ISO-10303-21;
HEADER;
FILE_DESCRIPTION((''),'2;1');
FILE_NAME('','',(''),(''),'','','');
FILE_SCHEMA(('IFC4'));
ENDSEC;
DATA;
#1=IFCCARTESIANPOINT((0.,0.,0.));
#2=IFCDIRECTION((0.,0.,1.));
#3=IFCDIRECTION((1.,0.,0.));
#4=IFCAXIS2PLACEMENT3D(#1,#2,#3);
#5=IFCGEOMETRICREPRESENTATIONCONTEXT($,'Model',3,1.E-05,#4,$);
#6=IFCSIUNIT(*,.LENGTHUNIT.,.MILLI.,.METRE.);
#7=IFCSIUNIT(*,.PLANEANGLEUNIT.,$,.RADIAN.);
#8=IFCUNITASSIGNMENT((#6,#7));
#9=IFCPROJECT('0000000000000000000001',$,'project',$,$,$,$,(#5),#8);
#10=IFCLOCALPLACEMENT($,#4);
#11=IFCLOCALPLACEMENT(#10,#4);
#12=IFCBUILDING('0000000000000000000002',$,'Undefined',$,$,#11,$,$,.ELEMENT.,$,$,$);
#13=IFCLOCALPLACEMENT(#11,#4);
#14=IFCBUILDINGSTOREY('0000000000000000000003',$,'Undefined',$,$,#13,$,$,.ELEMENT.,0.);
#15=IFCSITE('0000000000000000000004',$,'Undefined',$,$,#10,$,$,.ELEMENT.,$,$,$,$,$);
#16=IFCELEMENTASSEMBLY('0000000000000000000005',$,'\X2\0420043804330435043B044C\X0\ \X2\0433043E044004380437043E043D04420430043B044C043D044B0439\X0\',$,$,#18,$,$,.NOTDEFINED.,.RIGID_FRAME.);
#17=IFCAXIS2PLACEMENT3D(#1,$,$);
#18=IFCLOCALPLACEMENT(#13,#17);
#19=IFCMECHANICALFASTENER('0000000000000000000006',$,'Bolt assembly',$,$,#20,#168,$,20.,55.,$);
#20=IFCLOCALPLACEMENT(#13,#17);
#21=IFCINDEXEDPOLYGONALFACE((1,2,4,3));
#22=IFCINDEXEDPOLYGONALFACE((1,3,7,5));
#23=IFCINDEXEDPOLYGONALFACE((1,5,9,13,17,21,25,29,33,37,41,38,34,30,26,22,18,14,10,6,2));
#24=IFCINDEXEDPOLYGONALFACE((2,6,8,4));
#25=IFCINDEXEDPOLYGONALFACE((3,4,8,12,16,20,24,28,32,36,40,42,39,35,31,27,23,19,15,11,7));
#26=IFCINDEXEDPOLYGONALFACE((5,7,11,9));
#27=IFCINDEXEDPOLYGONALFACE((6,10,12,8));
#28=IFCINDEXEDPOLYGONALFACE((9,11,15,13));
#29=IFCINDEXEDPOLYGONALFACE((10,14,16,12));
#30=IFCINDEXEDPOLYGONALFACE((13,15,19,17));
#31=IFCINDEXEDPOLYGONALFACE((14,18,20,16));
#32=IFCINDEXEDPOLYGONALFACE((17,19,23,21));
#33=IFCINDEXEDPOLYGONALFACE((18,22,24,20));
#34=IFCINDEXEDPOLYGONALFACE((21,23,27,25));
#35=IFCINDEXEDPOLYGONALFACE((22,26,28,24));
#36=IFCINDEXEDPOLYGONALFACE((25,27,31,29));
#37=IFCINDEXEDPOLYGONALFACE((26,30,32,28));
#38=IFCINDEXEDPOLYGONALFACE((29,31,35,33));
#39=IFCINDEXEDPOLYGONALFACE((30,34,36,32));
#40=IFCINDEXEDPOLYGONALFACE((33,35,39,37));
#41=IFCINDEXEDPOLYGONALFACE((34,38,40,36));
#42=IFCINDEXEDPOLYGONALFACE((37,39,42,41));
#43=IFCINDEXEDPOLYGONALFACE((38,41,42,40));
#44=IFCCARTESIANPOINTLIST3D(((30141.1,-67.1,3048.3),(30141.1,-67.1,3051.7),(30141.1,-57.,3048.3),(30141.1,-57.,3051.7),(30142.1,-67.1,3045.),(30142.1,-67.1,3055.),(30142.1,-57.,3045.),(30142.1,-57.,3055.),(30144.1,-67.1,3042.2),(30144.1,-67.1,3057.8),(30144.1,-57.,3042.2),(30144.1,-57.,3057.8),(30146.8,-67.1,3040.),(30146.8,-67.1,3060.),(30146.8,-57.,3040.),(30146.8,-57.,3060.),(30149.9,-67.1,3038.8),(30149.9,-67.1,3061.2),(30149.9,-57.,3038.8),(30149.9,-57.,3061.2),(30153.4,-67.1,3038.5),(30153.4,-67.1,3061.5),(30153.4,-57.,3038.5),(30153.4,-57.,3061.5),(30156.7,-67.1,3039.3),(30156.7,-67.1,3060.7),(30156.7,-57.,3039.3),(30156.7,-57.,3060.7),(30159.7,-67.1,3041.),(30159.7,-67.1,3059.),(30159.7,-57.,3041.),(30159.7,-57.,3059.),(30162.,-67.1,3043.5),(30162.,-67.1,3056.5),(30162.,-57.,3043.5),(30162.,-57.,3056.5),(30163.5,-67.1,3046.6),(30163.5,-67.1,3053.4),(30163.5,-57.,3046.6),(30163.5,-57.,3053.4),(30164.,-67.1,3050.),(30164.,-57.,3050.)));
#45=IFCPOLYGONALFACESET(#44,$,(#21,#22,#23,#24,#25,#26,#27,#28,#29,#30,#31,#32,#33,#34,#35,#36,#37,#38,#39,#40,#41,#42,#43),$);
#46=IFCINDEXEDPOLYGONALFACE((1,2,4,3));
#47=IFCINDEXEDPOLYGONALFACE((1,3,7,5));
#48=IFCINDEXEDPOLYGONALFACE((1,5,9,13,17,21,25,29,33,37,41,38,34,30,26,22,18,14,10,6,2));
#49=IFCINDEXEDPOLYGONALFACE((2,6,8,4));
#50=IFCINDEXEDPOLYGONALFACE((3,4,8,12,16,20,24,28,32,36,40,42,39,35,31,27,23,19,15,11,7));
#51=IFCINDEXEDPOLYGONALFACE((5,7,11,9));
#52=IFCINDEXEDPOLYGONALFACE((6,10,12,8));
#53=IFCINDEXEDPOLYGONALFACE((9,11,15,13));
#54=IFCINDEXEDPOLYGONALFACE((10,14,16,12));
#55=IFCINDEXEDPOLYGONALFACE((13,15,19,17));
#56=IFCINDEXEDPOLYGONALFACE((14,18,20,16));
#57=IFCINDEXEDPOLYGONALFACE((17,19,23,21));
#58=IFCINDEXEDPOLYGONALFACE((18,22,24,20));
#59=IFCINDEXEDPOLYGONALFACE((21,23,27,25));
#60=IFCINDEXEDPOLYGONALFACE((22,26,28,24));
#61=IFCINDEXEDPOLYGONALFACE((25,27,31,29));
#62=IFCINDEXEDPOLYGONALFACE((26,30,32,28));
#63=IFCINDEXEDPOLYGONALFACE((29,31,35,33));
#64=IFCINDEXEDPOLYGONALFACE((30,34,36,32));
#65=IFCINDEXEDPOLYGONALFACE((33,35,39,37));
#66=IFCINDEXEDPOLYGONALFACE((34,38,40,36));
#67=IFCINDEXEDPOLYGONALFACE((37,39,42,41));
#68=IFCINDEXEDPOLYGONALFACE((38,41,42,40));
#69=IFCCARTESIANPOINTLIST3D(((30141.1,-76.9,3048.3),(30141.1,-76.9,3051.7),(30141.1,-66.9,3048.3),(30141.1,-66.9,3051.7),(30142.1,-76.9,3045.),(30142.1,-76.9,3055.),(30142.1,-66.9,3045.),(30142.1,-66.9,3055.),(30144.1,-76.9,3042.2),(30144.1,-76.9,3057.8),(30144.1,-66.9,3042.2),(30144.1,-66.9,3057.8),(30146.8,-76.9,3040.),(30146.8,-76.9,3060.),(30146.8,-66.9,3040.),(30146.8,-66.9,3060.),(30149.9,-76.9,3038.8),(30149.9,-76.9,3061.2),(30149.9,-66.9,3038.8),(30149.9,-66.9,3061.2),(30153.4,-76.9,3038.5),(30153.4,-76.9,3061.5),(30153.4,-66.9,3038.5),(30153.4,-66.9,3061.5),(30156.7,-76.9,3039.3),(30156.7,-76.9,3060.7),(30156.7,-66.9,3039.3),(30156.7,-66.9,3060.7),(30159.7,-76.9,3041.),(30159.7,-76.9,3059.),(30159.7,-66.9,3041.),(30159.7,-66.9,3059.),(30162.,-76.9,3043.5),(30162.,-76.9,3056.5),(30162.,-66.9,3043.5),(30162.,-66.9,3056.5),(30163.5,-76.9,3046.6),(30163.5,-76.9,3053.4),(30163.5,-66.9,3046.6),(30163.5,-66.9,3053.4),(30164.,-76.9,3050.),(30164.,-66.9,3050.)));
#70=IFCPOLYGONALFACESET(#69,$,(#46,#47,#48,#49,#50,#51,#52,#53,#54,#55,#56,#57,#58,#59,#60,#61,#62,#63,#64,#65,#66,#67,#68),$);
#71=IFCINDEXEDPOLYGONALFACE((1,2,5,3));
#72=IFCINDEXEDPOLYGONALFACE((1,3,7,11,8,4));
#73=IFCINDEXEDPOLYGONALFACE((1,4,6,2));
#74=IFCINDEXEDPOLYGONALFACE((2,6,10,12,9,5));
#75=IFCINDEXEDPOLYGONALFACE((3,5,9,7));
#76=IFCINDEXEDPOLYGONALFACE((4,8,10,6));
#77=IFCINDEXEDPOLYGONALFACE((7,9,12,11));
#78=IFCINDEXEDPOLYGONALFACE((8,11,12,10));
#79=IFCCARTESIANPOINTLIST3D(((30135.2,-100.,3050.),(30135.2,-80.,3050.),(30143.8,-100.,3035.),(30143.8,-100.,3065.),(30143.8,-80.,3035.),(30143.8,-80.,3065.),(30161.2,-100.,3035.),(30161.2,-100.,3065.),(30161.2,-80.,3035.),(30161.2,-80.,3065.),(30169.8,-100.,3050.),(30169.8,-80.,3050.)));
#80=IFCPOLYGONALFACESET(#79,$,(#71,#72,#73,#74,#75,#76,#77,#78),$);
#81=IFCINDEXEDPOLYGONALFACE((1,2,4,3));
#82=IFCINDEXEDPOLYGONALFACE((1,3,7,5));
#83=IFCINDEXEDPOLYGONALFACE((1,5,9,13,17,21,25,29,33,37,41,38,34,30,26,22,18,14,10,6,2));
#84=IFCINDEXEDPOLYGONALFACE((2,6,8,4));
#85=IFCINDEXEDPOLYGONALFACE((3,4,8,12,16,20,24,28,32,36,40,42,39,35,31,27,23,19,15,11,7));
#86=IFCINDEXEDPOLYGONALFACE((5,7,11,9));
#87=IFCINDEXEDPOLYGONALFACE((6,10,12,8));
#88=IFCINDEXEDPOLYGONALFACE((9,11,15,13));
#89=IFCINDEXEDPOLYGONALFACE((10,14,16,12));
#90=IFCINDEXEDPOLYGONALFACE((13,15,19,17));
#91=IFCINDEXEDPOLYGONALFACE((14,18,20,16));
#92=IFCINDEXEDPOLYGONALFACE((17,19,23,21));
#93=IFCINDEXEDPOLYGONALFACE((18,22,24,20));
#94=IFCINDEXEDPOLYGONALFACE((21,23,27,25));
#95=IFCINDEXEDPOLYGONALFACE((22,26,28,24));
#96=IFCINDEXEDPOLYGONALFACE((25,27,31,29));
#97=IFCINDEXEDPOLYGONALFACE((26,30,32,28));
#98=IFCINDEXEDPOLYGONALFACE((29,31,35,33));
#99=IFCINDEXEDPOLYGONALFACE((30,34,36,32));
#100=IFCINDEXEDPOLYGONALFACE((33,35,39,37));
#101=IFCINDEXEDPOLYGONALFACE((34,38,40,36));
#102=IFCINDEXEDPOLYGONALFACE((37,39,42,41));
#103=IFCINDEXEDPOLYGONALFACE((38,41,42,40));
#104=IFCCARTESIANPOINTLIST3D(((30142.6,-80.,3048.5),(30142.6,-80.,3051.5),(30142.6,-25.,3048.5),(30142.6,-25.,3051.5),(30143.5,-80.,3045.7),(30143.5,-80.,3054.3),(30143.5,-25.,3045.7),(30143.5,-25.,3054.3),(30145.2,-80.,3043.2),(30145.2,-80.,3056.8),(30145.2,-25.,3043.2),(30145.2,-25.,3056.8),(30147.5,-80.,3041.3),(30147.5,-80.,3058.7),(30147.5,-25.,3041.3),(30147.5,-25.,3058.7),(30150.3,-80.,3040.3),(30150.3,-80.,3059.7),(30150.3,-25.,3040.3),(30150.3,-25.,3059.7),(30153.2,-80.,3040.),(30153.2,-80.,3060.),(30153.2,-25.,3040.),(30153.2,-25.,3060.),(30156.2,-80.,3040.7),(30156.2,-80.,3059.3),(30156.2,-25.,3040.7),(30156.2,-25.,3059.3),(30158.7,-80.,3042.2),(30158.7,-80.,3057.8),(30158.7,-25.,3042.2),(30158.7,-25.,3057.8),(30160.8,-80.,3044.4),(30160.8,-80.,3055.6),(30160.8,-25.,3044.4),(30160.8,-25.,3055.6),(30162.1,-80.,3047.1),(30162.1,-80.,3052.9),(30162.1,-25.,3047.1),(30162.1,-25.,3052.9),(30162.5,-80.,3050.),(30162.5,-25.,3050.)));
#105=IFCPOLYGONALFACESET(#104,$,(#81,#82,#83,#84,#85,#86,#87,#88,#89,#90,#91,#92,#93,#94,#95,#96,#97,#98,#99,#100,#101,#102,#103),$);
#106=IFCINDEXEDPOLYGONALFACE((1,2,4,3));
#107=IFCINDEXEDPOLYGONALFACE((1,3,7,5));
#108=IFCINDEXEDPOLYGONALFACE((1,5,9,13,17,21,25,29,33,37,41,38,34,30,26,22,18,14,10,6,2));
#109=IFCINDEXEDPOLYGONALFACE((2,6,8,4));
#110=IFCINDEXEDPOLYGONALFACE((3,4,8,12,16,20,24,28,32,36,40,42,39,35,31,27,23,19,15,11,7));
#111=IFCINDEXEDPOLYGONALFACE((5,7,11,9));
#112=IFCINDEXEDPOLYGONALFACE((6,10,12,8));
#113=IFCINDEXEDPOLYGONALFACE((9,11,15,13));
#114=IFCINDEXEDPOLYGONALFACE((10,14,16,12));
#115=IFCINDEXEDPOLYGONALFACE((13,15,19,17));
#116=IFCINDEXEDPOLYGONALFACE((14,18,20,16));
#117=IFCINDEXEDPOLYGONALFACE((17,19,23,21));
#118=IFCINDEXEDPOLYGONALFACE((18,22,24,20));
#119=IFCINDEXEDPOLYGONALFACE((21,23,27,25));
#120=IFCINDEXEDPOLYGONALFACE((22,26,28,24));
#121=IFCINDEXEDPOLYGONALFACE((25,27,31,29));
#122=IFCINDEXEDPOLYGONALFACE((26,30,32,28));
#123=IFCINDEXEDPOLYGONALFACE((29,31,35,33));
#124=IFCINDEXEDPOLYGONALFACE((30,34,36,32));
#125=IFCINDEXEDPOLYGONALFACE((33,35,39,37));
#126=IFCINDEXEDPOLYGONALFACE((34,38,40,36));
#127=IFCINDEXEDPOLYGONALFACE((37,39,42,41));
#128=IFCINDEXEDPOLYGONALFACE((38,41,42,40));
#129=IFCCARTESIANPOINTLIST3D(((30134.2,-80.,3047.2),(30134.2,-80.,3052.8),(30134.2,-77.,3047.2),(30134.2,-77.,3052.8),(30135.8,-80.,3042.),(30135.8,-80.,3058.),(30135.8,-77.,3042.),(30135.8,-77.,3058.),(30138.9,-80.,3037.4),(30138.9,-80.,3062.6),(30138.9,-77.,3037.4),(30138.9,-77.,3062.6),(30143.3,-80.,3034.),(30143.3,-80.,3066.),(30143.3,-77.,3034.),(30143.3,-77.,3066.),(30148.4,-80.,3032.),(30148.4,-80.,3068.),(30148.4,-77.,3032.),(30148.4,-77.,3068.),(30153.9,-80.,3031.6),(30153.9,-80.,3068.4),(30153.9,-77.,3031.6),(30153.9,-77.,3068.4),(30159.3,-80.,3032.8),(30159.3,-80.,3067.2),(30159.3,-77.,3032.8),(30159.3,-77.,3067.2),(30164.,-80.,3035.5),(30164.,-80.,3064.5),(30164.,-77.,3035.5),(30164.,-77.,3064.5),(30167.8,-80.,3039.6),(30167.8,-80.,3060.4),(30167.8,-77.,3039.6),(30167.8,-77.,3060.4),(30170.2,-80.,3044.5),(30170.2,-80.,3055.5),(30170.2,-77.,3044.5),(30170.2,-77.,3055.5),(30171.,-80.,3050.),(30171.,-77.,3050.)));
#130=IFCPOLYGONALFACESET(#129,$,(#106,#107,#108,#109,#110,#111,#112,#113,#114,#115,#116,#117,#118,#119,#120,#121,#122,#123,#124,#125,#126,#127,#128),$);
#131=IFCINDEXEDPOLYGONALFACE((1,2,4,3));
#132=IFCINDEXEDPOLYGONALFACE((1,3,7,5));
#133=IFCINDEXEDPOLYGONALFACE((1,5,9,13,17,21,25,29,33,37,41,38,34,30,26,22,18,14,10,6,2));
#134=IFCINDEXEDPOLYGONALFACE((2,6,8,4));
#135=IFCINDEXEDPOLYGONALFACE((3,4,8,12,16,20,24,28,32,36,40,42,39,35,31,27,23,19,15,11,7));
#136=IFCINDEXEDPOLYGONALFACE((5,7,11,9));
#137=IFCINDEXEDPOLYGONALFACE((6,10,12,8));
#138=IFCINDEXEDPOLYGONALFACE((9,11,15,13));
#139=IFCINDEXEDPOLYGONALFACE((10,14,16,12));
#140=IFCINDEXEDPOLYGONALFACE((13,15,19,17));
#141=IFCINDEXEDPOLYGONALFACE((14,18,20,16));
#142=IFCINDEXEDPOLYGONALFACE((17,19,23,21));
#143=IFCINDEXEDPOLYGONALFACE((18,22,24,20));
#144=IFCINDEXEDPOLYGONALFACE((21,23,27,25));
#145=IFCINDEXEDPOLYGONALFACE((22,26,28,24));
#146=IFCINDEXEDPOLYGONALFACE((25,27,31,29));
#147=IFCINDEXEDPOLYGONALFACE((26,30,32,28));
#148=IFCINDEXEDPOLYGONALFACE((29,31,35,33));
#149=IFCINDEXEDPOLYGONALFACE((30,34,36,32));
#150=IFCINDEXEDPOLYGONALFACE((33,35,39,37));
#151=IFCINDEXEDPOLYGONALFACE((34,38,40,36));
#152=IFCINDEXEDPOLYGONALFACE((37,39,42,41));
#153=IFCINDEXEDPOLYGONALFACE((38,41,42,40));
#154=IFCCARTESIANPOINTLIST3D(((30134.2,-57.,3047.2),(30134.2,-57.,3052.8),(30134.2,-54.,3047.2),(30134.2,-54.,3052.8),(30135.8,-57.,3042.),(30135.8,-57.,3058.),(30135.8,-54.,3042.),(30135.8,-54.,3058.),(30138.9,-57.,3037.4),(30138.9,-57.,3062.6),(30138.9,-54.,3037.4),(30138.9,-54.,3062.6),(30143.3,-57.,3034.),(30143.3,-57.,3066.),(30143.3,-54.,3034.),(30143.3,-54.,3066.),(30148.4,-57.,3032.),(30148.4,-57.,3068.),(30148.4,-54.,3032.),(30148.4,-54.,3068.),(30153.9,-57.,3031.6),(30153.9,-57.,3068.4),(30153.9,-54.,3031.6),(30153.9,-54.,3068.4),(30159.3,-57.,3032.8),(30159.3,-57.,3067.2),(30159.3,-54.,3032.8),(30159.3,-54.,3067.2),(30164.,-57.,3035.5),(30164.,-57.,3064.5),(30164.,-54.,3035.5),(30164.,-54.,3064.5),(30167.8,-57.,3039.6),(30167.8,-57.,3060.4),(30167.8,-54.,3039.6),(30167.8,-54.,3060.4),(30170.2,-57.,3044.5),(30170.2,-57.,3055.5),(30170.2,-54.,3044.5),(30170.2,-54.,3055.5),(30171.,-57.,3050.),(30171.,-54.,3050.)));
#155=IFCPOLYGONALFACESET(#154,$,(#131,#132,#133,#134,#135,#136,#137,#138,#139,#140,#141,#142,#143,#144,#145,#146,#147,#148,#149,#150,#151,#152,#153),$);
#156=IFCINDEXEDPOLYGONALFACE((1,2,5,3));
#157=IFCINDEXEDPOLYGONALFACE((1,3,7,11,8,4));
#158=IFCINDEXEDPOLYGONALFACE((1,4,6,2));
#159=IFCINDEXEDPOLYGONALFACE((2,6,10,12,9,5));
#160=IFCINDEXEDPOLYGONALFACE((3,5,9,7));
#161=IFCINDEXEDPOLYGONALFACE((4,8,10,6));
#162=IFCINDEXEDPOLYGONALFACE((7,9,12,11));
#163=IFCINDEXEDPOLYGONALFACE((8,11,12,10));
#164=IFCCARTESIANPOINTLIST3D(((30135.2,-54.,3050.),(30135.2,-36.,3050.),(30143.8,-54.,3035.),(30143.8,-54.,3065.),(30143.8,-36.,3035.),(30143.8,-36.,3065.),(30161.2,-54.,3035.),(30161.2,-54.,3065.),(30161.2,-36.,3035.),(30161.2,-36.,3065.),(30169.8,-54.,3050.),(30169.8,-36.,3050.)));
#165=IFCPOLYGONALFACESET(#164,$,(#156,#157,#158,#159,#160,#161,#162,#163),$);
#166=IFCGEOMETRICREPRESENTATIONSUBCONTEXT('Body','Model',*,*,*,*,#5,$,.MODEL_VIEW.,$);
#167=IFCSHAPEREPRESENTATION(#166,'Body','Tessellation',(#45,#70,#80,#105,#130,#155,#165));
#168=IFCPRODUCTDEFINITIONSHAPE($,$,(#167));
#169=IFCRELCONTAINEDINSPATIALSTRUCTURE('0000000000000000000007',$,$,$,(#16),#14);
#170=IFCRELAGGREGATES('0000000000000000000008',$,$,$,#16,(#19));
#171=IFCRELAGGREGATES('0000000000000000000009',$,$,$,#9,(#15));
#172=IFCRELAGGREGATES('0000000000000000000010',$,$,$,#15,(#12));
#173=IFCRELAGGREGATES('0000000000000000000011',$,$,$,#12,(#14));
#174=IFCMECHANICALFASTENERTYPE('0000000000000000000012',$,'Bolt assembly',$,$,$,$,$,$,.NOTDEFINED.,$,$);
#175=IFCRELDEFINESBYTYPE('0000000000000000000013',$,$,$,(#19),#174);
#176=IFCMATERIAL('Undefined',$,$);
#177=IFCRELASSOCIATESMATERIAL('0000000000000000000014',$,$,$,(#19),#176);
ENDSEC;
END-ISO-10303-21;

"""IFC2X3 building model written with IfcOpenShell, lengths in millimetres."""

from ifc_helpers import new_model, si_unit, frame, origin_with_axes, origin_2d_with_axis, place, context, subcontext, project, spatial, polyline, circle, outline, extrude, source, transform, mapped, material, type_object, element, aggregate, save


model = new_model("IFC2X3")

# Units and contexts
model_context = context("Model", 3, precision=1e-05, world=origin_with_axes())
body_context = subcontext(model_context, "Body", "Model", "MODEL_VIEW")
ifc_project = project(units=[si_unit("LENGTHUNIT", "METRE", prefix="MILLI"), si_unit("PLANEANGLEUNIT", "RADIAN")], contexts=[model_context])

# Site, building, storey
site_placement = place(None, origin_with_axes())
site = spatial("IfcSite", under=ifc_project, at=site_placement, Name="Undefined", CompositionType="ELEMENT")
building_placement = place(site_placement, origin_with_axes())
building = spatial("IfcBuilding", under=site, at=building_placement, Name="Undefined", CompositionType="ELEMENT")
storey_placement = place(building_placement, origin_with_axes())
storey = spatial("IfcBuildingStorey", under=building, at=storey_placement, Name="Undefined", CompositionType="ELEMENT", Elevation=0.0)

# Element assembly
assembly_1_placement = place(storey_placement, origin_with_axes())
assembly_1 = element("IfcElementAssembly", 1, at=assembly_1_placement, inside=storey, Name="Ригель горизонтальный", AssemblyPlace="NOTDEFINED", PredefinedType="RIGID_FRAME")

# Mechanical fastener
ifc_material_1 = material(Name="Undefined")
mechanical_fastener_type = type_object("IfcMechanicalFastenerType", Name="Bolt assembly")
shared_shape_1 = source(origin_with_axes(), body_context, "Body", "SweptSolid", [
    extrude(circle(Radius=11.5, at=origin_2d_with_axis()), frame((0.0, -0.1, 0.0), z_axis=(0.0, 1.0, 0.0), x_axis=(1.0, 0.0, 0.0)), (0.0, 0.0, 1.0), 10.1),
    extrude(circle(Radius=11.5, at=origin_2d_with_axis()), frame((0.0, -9.9, 0.0), z_axis=(0.0, 1.0, 0.0), x_axis=(1.0, 0.0, 0.0)), (0.0, 0.0, 1.0), 10.0),
    extrude(outline(polyline([(17.3, 0.0), (8.7, 15.0), (-8.7, 15.0), (-17.3, 0.0), (-8.7, -15.0), (8.7, -15.0), (17.3, 0.0)])), frame((0.0, -33.0, 0.0), z_axis=(0.0, 1.0, 0.0), x_axis=(1.0, 0.0, 0.0)), (0.0, 0.0, 1.0), 20.0),
    extrude(circle(Radius=10.0, at=origin_2d_with_axis()), frame((0.0, -13.0, 0.0), z_axis=(0.0, 1.0, 0.0), x_axis=(1.0, 0.0, 0.0)), (0.0, 0.0, 1.0), 55.0),
    extrude(circle(Radius=18.5, at=origin_2d_with_axis()), frame((0.0, -13.0, 0.0), z_axis=(0.0, 1.0, 0.0), x_axis=(1.0, 0.0, 0.0)), (0.0, 0.0, 1.0), 3.0),
    extrude(circle(Radius=18.5, at=origin_2d_with_axis()), frame((0.0, 10.0, 0.0), z_axis=(0.0, 1.0, 0.0), x_axis=(1.0, 0.0, 0.0)), (0.0, 0.0, 1.0), 3.0),
    extrude(outline(polyline([(17.3, 0.0), (8.7, 15.0), (-8.7, 15.0), (-17.3, 0.0), (-8.7, -15.0), (8.7, -15.0), (17.3, 0.0)])), frame((0.0, 13.0, 0.0), z_axis=(0.0, 1.0, 0.0), x_axis=(1.0, 0.0, 0.0)), (0.0, 0.0, 1.0), 18.0),
])
mechanical_fastener_1_placement = place(assembly_1_placement, frame((30152.5, -67.0, 3050.0), z_axis=(0.0, 0.0, 1.0), x_axis=(1.0, 0.0, 0.0)))
mechanical_fastener_1 = element("IfcMechanicalFastener", 2, at=mechanical_fastener_1_placement, type_object=mechanical_fastener_type, material=ifc_material_1, Name="Bolt assembly", NominalDiameter=20.0, NominalLength=55.0, context=body_context, shape_type="MappedRepresentation", body=[
    mapped(shared_shape_1, transform((0.0, 0.0, 0.0))),
])
aggregate(assembly_1, [mechanical_fastener_1])

save(model, "model.ifc")
